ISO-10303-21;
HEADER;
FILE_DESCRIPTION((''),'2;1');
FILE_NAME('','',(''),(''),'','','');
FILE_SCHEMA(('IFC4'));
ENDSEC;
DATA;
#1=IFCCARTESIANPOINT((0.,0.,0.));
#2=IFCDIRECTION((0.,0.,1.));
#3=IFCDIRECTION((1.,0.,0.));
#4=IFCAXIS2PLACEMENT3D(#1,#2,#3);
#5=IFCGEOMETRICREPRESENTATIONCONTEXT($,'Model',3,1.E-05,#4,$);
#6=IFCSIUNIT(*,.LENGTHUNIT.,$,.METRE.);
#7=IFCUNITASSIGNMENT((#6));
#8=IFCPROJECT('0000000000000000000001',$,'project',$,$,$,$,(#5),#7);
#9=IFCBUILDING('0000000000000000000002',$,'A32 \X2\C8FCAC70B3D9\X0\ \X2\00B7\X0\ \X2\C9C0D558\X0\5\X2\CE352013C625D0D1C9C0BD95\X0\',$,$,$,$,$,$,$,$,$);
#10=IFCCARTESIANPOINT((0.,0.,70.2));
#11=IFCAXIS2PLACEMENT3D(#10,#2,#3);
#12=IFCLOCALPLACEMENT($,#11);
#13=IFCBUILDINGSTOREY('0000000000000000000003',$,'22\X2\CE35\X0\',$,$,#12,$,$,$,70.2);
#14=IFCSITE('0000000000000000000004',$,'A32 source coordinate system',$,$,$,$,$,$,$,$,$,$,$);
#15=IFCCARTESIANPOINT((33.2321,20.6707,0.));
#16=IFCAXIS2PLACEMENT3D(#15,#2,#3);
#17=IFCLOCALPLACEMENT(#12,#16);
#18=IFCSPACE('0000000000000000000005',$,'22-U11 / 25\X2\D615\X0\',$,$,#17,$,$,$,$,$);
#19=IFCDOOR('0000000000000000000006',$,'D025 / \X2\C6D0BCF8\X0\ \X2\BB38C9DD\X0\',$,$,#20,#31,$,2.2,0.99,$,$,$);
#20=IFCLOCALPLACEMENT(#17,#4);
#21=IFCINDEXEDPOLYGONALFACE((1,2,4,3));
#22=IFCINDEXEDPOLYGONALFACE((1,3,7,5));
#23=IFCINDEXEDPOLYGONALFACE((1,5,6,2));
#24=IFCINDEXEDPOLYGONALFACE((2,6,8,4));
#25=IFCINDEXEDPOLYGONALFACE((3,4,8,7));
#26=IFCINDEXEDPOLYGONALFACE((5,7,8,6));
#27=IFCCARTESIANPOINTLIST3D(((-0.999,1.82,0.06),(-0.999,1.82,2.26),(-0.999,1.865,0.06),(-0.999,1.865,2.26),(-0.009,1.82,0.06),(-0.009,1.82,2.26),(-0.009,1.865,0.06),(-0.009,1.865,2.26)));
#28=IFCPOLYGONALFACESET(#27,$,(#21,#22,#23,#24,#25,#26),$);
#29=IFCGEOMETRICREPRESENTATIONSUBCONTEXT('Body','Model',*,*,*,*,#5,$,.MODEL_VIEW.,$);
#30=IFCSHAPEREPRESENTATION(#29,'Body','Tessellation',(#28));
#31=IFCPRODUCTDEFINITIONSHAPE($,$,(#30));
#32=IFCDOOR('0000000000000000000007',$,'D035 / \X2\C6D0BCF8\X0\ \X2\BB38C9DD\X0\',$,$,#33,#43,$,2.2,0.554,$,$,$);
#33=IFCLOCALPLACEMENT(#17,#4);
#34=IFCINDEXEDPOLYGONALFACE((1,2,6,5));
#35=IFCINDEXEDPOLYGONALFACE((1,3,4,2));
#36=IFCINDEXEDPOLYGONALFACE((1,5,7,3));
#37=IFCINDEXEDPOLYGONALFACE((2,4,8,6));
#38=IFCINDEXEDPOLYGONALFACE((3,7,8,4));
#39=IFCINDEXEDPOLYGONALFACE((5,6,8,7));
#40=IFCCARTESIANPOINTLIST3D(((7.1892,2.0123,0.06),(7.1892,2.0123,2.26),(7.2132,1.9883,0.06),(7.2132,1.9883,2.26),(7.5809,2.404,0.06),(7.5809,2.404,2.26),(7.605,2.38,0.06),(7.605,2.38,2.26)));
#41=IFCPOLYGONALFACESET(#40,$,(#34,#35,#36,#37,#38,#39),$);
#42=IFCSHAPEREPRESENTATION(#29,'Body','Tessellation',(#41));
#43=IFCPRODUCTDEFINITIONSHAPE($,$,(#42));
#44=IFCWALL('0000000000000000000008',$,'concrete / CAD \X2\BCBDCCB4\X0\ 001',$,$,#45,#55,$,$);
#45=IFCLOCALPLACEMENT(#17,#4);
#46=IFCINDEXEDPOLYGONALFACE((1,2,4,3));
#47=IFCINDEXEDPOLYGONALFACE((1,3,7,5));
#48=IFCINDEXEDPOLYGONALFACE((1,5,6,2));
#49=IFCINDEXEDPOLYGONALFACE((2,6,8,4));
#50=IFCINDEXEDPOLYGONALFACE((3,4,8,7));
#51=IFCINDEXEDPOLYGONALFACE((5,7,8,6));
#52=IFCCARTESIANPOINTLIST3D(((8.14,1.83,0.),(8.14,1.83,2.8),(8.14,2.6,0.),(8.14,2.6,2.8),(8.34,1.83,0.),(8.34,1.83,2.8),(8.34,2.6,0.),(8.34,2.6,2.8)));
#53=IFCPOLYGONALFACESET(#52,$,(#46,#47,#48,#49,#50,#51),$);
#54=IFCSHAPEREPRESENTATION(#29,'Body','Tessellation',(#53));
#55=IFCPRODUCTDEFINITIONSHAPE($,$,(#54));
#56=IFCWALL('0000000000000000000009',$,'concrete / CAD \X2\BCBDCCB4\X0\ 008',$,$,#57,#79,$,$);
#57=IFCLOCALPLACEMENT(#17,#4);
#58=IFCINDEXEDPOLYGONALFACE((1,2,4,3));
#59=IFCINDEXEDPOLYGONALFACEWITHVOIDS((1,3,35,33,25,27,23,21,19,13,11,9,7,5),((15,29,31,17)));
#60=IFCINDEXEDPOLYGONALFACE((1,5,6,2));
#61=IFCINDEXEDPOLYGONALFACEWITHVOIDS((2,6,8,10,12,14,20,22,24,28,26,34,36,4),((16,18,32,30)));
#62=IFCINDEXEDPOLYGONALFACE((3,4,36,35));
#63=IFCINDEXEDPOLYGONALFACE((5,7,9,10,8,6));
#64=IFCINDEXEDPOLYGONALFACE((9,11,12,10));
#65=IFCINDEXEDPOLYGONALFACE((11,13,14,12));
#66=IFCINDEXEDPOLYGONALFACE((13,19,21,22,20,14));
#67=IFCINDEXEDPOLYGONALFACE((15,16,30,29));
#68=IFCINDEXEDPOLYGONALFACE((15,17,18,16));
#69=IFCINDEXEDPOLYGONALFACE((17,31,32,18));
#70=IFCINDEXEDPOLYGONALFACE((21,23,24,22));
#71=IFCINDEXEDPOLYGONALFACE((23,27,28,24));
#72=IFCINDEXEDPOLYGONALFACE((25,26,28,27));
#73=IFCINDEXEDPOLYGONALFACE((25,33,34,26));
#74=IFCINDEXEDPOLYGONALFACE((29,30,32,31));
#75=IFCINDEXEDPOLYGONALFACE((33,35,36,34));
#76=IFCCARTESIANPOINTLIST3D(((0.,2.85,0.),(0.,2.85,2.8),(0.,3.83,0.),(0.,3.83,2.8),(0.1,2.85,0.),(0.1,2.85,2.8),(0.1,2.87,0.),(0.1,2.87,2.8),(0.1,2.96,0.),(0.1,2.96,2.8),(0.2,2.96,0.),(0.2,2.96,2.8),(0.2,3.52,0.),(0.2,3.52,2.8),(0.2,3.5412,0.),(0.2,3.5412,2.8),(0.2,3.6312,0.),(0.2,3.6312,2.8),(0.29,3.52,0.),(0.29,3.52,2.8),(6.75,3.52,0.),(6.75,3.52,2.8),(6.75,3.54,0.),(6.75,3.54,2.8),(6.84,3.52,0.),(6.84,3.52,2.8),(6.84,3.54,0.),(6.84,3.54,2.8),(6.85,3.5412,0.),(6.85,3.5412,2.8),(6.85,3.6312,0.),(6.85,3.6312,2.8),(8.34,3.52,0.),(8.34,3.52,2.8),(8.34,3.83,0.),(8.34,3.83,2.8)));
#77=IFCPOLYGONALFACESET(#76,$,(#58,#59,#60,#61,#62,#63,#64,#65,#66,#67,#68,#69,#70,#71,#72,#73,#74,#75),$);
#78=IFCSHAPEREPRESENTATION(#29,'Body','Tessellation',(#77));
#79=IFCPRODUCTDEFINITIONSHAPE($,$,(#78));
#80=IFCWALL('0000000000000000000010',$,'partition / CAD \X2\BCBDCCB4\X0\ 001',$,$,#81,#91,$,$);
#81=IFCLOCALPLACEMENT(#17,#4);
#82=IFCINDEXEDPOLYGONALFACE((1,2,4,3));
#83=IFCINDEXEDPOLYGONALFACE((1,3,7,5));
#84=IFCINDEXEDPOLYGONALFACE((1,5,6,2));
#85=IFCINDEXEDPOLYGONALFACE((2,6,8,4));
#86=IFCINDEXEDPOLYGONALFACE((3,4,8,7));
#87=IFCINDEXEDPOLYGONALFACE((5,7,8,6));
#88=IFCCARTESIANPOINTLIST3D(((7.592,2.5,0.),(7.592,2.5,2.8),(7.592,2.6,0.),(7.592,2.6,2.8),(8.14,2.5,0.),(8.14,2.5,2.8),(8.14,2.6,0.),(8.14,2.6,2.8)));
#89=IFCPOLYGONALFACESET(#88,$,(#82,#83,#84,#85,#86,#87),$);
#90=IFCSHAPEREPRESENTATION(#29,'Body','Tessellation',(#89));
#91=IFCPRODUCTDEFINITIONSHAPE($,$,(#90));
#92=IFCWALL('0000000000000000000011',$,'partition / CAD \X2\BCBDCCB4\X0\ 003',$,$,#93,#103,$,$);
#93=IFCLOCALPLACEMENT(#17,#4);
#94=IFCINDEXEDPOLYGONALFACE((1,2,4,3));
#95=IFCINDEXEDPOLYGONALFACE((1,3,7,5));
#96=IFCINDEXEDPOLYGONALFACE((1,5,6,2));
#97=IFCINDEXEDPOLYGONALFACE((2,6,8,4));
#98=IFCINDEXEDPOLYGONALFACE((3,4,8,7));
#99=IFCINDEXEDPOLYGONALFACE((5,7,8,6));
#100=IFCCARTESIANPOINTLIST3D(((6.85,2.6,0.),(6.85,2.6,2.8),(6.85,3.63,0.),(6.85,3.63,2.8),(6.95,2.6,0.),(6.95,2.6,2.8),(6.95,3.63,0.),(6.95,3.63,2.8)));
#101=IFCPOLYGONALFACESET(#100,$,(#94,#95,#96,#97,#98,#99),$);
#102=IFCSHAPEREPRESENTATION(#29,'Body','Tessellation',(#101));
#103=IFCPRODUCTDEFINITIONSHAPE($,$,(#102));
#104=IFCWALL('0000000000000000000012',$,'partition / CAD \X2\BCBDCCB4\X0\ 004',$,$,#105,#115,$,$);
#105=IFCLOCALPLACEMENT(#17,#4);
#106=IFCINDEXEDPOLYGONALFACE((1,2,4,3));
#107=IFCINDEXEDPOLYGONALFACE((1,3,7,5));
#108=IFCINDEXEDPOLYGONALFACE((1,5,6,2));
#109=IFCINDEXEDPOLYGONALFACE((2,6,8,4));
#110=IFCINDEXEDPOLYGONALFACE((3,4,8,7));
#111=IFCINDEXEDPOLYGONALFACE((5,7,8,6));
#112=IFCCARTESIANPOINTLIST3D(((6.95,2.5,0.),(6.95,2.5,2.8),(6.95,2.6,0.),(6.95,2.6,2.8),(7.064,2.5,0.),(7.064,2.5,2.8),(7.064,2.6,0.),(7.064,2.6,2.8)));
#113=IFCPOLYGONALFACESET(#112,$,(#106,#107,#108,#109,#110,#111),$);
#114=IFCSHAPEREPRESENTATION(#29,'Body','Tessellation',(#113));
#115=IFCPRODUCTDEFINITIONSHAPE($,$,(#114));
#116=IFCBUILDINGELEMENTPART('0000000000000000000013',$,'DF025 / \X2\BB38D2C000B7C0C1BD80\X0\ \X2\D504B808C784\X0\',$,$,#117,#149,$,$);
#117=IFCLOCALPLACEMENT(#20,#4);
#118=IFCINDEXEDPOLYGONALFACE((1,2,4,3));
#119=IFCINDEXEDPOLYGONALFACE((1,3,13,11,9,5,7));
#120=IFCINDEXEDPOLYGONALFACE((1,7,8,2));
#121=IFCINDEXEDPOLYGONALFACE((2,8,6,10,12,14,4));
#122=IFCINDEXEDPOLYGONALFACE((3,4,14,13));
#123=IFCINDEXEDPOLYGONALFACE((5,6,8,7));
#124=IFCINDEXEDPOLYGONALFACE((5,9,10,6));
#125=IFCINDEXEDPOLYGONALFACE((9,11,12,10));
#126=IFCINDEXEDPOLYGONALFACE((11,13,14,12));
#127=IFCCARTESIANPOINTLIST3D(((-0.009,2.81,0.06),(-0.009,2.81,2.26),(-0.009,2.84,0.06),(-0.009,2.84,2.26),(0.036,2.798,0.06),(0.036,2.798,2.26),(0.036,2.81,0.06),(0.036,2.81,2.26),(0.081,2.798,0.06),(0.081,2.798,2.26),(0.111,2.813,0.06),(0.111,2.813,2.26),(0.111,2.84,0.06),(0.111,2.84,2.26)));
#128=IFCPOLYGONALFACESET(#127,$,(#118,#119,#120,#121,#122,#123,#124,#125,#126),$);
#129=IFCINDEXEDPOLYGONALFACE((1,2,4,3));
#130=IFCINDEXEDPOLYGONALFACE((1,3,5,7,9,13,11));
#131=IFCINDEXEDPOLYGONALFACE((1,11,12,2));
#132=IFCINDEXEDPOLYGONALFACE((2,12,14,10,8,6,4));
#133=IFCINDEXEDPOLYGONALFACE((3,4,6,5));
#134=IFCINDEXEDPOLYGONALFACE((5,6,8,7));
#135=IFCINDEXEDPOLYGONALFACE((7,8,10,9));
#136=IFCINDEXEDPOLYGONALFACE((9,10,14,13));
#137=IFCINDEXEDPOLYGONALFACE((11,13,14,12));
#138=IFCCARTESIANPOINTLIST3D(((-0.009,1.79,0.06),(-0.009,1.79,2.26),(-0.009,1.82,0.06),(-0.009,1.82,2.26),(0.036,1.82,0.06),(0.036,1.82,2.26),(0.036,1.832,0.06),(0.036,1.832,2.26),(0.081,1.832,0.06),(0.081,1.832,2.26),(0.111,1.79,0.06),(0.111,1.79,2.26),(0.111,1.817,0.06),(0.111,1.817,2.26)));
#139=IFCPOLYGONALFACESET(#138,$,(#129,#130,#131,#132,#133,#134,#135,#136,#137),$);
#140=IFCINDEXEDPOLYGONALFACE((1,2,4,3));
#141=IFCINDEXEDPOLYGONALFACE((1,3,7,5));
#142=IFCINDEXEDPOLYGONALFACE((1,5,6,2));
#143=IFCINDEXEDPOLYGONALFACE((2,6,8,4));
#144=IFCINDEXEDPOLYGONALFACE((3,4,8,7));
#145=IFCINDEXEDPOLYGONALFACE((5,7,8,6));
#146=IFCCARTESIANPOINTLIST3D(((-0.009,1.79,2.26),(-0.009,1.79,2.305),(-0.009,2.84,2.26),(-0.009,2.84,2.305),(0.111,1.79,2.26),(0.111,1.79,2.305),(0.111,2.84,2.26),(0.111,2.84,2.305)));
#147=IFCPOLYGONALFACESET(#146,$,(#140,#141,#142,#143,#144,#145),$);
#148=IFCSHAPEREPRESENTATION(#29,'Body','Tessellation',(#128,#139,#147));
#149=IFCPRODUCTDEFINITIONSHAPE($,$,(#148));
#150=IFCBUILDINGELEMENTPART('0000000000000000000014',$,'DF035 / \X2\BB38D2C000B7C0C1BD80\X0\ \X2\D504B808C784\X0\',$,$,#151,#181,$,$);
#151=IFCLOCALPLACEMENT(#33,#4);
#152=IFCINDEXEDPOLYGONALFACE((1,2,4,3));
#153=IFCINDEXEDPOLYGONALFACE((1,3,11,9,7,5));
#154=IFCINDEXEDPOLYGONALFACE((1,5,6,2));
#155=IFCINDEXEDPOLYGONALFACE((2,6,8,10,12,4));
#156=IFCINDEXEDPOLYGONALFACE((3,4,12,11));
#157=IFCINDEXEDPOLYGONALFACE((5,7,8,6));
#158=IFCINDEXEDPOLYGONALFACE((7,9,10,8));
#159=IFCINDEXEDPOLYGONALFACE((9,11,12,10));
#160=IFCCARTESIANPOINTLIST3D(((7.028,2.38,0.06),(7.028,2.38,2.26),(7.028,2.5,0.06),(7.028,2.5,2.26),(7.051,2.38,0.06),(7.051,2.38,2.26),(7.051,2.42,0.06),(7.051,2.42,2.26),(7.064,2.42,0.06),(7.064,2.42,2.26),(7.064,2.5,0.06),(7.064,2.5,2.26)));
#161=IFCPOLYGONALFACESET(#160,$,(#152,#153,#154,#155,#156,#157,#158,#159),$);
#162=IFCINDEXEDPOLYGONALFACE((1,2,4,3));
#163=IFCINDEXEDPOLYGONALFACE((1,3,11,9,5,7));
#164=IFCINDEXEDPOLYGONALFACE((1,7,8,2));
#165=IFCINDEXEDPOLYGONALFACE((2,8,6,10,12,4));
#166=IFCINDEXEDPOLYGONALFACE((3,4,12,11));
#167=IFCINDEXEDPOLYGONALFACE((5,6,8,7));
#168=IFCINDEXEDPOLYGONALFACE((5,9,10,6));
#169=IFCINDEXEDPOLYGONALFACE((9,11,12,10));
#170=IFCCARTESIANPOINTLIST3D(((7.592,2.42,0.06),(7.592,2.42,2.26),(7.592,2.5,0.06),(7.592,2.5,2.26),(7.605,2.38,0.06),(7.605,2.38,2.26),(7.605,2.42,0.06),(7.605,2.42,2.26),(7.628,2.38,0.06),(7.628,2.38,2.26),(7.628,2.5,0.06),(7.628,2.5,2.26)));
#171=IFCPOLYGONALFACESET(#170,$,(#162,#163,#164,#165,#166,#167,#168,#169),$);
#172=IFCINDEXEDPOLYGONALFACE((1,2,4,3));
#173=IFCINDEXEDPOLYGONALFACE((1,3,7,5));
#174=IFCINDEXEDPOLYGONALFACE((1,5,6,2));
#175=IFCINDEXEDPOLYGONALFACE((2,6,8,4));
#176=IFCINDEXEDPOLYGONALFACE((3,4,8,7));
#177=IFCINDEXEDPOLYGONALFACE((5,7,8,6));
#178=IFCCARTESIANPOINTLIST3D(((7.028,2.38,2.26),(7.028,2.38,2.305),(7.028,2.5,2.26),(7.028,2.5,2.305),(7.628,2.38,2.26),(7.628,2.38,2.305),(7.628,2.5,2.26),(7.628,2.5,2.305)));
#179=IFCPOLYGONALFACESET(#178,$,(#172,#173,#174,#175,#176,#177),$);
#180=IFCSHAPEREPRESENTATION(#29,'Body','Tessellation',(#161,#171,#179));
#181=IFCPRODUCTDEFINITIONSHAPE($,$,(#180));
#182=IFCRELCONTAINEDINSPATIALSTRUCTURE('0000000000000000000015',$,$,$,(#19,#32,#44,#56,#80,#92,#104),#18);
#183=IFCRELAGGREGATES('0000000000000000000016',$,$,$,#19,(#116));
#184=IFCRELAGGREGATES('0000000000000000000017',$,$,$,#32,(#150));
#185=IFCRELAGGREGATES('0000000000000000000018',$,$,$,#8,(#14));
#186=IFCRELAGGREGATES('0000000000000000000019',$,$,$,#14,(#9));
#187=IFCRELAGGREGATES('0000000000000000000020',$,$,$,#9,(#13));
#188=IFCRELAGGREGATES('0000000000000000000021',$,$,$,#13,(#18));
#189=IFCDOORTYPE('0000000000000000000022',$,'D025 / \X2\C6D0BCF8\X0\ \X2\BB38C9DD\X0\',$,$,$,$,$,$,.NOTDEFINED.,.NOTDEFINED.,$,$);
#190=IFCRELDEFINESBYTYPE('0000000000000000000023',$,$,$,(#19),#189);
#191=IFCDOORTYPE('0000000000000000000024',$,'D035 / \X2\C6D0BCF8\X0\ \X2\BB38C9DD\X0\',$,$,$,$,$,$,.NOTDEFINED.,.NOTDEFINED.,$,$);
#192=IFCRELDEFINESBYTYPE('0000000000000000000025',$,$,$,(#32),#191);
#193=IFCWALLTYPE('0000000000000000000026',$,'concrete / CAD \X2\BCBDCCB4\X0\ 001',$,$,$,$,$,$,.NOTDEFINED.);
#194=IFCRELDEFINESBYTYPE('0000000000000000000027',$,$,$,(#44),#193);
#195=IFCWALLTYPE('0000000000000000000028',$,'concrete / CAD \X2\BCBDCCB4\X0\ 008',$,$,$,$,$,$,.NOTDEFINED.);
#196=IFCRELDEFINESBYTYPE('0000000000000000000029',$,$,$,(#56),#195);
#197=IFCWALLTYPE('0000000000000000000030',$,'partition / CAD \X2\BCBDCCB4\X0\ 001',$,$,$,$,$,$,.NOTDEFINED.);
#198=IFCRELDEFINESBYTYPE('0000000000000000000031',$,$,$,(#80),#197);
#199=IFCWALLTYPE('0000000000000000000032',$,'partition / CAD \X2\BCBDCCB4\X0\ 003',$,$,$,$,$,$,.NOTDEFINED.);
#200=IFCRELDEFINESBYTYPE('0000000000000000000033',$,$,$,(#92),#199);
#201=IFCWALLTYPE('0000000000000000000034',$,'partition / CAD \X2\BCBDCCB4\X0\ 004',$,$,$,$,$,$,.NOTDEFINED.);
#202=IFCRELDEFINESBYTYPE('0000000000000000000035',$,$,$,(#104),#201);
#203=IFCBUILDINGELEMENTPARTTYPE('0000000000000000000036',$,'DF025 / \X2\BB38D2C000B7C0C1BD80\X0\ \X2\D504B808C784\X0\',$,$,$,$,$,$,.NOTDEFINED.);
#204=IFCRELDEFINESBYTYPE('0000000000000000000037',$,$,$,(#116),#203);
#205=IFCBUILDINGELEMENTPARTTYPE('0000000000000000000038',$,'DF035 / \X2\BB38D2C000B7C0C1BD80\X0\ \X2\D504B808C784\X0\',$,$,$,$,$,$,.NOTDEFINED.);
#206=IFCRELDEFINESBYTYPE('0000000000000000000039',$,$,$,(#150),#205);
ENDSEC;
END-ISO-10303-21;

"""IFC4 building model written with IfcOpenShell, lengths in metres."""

from ifc_helpers import new_model, si_unit, frame, origin, origin_with_axes, place, context, subcontext, project, spatial, polyline, outline, extrude, source, transform, mapped, type_object, type_shapes, element, aggregate, save


model = new_model("IFC4")

# Units and contexts
model_context = context("Model", 3, precision=1e-05, world=origin_with_axes())
body_context = subcontext(model_context, "Body", "Model", "MODEL_VIEW")
ifc_project = project(units=[si_unit("LENGTHUNIT", "METRE")], contexts=[model_context])

# Site, building, storey, space
storey_placement = place(None, frame((0.0, 0.0, 70.2), z_axis=(0.0, 0.0, 1.0), x_axis=(1.0, 0.0, 0.0)))
space_placement = place(storey_placement, frame((33.2321, 20.6707, 0.0), z_axis=(0.0, 0.0, 1.0), x_axis=(1.0, 0.0, 0.0)))
site = spatial("IfcSite", under=ifc_project, Name="A32 source coordinate system")
building = spatial("IfcBuilding", under=site, Name="A32 주거동 · 지하5층–옥탑지붕")
storey = spatial("IfcBuildingStorey", under=building, at=storey_placement, Name="22층", Elevation=70.2)
space = spatial("IfcSpace", under=storey, at=space_placement, Name="22-U11 / 25형")

# Doors
door_type_1 = type_object("IfcDoorType", Name="D025 / 원본 문짝", OperationType="NOTDEFINED", PredefinedType="NOTDEFINED")
shared_shape_1 = source(origin(), body_context, "Body", "SweptSolid", [
    extrude(outline(polyline([(-0.009, 1.82), (-0.999, 1.82), (-0.999, 1.865), (-0.009, 1.865), (-0.009, 1.82)])), frame((0.0, 0.0, 0.06)), (0.0, 0.0, 1.0), 2.2),
])
type_shapes(door_type_1, [shared_shape_1])
door_1_placement = place(space_placement, origin_with_axes())
door_1 = element("IfcDoor", 1, at=door_1_placement, inside=space, type_object=door_type_1, Name="D025 / 원본 문짝", OverallHeight=2.2, OverallWidth=0.99, context=body_context, shape_type="MappedRepresentation", body=[
    mapped(shared_shape_1, transform((0.0, 0.0, 0.0), scale=1.0)),
])
door_type_2 = type_object("IfcDoorType", Name="D035 / 원본 문짝", OperationType="NOTDEFINED", PredefinedType="NOTDEFINED")
shared_shape_2 = source(origin(), body_context, "Body", "SweptSolid", [
    extrude(outline(polyline([(7.605, 2.38), (7.2132, 1.9883), (7.1892, 2.0123), (7.5809, 2.404), (7.605, 2.38)])), frame((0.0, 0.0, 0.06)), (0.0, 0.0, 1.0), 2.2),
])
type_shapes(door_type_2, [shared_shape_2])
door_2_placement = place(space_placement, origin_with_axes())
door_2 = element("IfcDoor", 2, at=door_2_placement, inside=space, type_object=door_type_2, Name="D035 / 원본 문짝", OverallHeight=2.2, OverallWidth=0.554, context=body_context, shape_type="MappedRepresentation", body=[
    mapped(shared_shape_2, transform((0.0, 0.0, 0.0), scale=1.0)),
])

# Walls
wall_type_1 = type_object("IfcWallType", Name="concrete / CAD 벽체 001", PredefinedType="NOTDEFINED")
shared_shape_3 = source(origin(), body_context, "Body", "SweptSolid", [
    extrude(outline(polyline([(8.34, 1.83), (8.14, 1.83), (8.14, 2.6), (8.34, 2.6), (8.34, 1.83)])), origin(), (0.0, 0.0, 1.0), 2.8),
])
type_shapes(wall_type_1, [shared_shape_3])
wall_1_placement = place(space_placement, origin_with_axes())
element("IfcWall", 3, at=wall_1_placement, inside=space, type_object=wall_type_1, Name="concrete / CAD 벽체 001", context=body_context, shape_type="MappedRepresentation", body=[
    mapped(shared_shape_3, transform((0.0, 0.0, 0.0), scale=1.0)),
])
wall_type_2 = type_object("IfcWallType", Name="concrete / CAD 벽체 008", PredefinedType="NOTDEFINED")
shared_shape_4 = source(origin(), body_context, "Body", "SweptSolid", [
    extrude(outline(polyline([(0.0, 3.83), (8.34, 3.83), (8.34, 3.52), (6.84, 3.52), (6.84, 3.54), (6.75, 3.54), (6.75, 3.52), (0.29, 3.52), (0.2, 3.52), (0.2, 2.96), (0.1, 2.96), (0.1, 2.87), (0.1, 2.85), (0.0, 2.85), (0.0, 3.83)]), holes=[polyline([(6.85, 3.5412), (6.85, 3.6312), (0.2, 3.6312), (0.2, 3.5412), (6.85, 3.5412)])]), origin(), (0.0, 0.0, 1.0), 2.8),
])
type_shapes(wall_type_2, [shared_shape_4])
wall_2_placement = place(space_placement, origin_with_axes())
element("IfcWall", 4, at=wall_2_placement, inside=space, type_object=wall_type_2, Name="concrete / CAD 벽체 008", context=body_context, shape_type="MappedRepresentation", body=[
    mapped(shared_shape_4, transform((0.0, 0.0, 0.0), scale=1.0)),
])
wall_type_3 = type_object("IfcWallType", Name="partition / CAD 벽체 001", PredefinedType="NOTDEFINED")
shared_shape_5 = source(origin(), body_context, "Body", "SweptSolid", [
    extrude(outline(polyline([(8.14, 2.6), (8.14, 2.5), (7.592, 2.5), (7.592, 2.6), (8.14, 2.6)])), origin(), (0.0, 0.0, 1.0), 2.8),
])
type_shapes(wall_type_3, [shared_shape_5])
wall_3_placement = place(space_placement, origin_with_axes())
element("IfcWall", 5, at=wall_3_placement, inside=space, type_object=wall_type_3, Name="partition / CAD 벽체 001", context=body_context, shape_type="MappedRepresentation", body=[
    mapped(shared_shape_5, transform((0.0, 0.0, 0.0), scale=1.0)),
])
wall_type_4 = type_object("IfcWallType", Name="partition / CAD 벽체 003", PredefinedType="NOTDEFINED")
shared_shape_6 = source(origin(), body_context, "Body", "SweptSolid", [
    extrude(outline(polyline([(6.85, 2.6), (6.85, 3.63), (6.95, 3.63), (6.95, 2.6), (6.85, 2.6)])), origin(), (0.0, 0.0, 1.0), 2.8),
])
type_shapes(wall_type_4, [shared_shape_6])
wall_4_placement = place(space_placement, origin_with_axes())
element("IfcWall", 6, at=wall_4_placement, inside=space, type_object=wall_type_4, Name="partition / CAD 벽체 003", context=body_context, shape_type="MappedRepresentation", body=[
    mapped(shared_shape_6, transform((0.0, 0.0, 0.0), scale=1.0)),
])
wall_type_5 = type_object("IfcWallType", Name="partition / CAD 벽체 004", PredefinedType="NOTDEFINED")
shared_shape_7 = source(origin(), body_context, "Body", "SweptSolid", [
    extrude(outline(polyline([(6.95, 2.5), (6.95, 2.6), (7.064, 2.6), (7.064, 2.5), (6.95, 2.5)])), origin(), (0.0, 0.0, 1.0), 2.8),
])
type_shapes(wall_type_5, [shared_shape_7])
wall_5_placement = place(space_placement, origin_with_axes())
element("IfcWall", 7, at=wall_5_placement, inside=space, type_object=wall_type_5, Name="partition / CAD 벽체 004", context=body_context, shape_type="MappedRepresentation", body=[
    mapped(shared_shape_7, transform((0.0, 0.0, 0.0), scale=1.0)),
])

# Building element parts
building_element_part_type_1 = type_object("IfcBuildingElementPartType", Name="DF025 / 문틀·상부 프레임", PredefinedType="NOTDEFINED")
shared_shape_8 = source(origin(), body_context, "Body", "SweptSolid", [
    extrude(outline(polyline([(0.111, 2.84), (0.111, 2.813), (0.081, 2.798), (0.036, 2.798), (0.036, 2.81), (-0.009, 2.81), (-0.009, 2.84), (0.111, 2.84)])), frame((0.0, 0.0, 0.06)), (0.0, 0.0, 1.0), 2.2),
    extrude(outline(polyline([(-0.009, 1.82), (0.036, 1.82), (0.036, 1.832), (0.081, 1.832), (0.111, 1.817), (0.111, 1.79), (-0.009, 1.79), (-0.009, 1.82)])), frame((0.0, 0.0, 0.06)), (0.0, 0.0, 1.0), 2.2),
    extrude(outline(polyline([(-0.009, 1.79), (-0.009, 2.84), (0.111, 2.84), (0.111, 1.79), (-0.009, 1.79)])), frame((0.0, 0.0, 2.26)), (0.0, 0.0, 1.0), 0.045),
])
type_shapes(building_element_part_type_1, [shared_shape_8])
building_element_part_1_placement = place(door_1_placement, origin_with_axes())
building_element_part_1 = element("IfcBuildingElementPart", 8, at=building_element_part_1_placement, type_object=building_element_part_type_1, Name="DF025 / 문틀·상부 프레임", context=body_context, shape_type="MappedRepresentation", body=[
    mapped(shared_shape_8, transform((0.0, 0.0, 0.0), scale=1.0)),
])
aggregate(door_1, [building_element_part_1])
building_element_part_type_2 = type_object("IfcBuildingElementPartType", Name="DF035 / 문틀·상부 프레임", PredefinedType="NOTDEFINED")
shared_shape_9 = source(origin(), body_context, "Body", "SweptSolid", [
    extrude(outline(polyline([(7.064, 2.5), (7.064, 2.42), (7.051, 2.42), (7.051, 2.38), (7.028, 2.38), (7.028, 2.5), (7.064, 2.5)])), frame((0.0, 0.0, 0.06)), (0.0, 0.0, 1.0), 2.2),
    extrude(outline(polyline([(7.628, 2.38), (7.605, 2.38), (7.605, 2.42), (7.592, 2.42), (7.592, 2.5), (7.628, 2.5), (7.628, 2.38)])), frame((0.0, 0.0, 0.06)), (0.0, 0.0, 1.0), 2.2),
    extrude(outline(polyline([(7.028, 2.38), (7.028, 2.5), (7.628, 2.5), (7.628, 2.38), (7.028, 2.38)])), frame((0.0, 0.0, 2.26)), (0.0, 0.0, 1.0), 0.045),
])
type_shapes(building_element_part_type_2, [shared_shape_9])
building_element_part_2_placement = place(door_2_placement, origin_with_axes())
building_element_part_2 = element("IfcBuildingElementPart", 9, at=building_element_part_2_placement, type_object=building_element_part_type_2, Name="DF035 / 문틀·상부 프레임", context=body_context, shape_type="MappedRepresentation", body=[
    mapped(shared_shape_9, transform((0.0, 0.0, 0.0), scale=1.0)),
])
aggregate(door_2, [building_element_part_2])

save(model, "model.ifc")
